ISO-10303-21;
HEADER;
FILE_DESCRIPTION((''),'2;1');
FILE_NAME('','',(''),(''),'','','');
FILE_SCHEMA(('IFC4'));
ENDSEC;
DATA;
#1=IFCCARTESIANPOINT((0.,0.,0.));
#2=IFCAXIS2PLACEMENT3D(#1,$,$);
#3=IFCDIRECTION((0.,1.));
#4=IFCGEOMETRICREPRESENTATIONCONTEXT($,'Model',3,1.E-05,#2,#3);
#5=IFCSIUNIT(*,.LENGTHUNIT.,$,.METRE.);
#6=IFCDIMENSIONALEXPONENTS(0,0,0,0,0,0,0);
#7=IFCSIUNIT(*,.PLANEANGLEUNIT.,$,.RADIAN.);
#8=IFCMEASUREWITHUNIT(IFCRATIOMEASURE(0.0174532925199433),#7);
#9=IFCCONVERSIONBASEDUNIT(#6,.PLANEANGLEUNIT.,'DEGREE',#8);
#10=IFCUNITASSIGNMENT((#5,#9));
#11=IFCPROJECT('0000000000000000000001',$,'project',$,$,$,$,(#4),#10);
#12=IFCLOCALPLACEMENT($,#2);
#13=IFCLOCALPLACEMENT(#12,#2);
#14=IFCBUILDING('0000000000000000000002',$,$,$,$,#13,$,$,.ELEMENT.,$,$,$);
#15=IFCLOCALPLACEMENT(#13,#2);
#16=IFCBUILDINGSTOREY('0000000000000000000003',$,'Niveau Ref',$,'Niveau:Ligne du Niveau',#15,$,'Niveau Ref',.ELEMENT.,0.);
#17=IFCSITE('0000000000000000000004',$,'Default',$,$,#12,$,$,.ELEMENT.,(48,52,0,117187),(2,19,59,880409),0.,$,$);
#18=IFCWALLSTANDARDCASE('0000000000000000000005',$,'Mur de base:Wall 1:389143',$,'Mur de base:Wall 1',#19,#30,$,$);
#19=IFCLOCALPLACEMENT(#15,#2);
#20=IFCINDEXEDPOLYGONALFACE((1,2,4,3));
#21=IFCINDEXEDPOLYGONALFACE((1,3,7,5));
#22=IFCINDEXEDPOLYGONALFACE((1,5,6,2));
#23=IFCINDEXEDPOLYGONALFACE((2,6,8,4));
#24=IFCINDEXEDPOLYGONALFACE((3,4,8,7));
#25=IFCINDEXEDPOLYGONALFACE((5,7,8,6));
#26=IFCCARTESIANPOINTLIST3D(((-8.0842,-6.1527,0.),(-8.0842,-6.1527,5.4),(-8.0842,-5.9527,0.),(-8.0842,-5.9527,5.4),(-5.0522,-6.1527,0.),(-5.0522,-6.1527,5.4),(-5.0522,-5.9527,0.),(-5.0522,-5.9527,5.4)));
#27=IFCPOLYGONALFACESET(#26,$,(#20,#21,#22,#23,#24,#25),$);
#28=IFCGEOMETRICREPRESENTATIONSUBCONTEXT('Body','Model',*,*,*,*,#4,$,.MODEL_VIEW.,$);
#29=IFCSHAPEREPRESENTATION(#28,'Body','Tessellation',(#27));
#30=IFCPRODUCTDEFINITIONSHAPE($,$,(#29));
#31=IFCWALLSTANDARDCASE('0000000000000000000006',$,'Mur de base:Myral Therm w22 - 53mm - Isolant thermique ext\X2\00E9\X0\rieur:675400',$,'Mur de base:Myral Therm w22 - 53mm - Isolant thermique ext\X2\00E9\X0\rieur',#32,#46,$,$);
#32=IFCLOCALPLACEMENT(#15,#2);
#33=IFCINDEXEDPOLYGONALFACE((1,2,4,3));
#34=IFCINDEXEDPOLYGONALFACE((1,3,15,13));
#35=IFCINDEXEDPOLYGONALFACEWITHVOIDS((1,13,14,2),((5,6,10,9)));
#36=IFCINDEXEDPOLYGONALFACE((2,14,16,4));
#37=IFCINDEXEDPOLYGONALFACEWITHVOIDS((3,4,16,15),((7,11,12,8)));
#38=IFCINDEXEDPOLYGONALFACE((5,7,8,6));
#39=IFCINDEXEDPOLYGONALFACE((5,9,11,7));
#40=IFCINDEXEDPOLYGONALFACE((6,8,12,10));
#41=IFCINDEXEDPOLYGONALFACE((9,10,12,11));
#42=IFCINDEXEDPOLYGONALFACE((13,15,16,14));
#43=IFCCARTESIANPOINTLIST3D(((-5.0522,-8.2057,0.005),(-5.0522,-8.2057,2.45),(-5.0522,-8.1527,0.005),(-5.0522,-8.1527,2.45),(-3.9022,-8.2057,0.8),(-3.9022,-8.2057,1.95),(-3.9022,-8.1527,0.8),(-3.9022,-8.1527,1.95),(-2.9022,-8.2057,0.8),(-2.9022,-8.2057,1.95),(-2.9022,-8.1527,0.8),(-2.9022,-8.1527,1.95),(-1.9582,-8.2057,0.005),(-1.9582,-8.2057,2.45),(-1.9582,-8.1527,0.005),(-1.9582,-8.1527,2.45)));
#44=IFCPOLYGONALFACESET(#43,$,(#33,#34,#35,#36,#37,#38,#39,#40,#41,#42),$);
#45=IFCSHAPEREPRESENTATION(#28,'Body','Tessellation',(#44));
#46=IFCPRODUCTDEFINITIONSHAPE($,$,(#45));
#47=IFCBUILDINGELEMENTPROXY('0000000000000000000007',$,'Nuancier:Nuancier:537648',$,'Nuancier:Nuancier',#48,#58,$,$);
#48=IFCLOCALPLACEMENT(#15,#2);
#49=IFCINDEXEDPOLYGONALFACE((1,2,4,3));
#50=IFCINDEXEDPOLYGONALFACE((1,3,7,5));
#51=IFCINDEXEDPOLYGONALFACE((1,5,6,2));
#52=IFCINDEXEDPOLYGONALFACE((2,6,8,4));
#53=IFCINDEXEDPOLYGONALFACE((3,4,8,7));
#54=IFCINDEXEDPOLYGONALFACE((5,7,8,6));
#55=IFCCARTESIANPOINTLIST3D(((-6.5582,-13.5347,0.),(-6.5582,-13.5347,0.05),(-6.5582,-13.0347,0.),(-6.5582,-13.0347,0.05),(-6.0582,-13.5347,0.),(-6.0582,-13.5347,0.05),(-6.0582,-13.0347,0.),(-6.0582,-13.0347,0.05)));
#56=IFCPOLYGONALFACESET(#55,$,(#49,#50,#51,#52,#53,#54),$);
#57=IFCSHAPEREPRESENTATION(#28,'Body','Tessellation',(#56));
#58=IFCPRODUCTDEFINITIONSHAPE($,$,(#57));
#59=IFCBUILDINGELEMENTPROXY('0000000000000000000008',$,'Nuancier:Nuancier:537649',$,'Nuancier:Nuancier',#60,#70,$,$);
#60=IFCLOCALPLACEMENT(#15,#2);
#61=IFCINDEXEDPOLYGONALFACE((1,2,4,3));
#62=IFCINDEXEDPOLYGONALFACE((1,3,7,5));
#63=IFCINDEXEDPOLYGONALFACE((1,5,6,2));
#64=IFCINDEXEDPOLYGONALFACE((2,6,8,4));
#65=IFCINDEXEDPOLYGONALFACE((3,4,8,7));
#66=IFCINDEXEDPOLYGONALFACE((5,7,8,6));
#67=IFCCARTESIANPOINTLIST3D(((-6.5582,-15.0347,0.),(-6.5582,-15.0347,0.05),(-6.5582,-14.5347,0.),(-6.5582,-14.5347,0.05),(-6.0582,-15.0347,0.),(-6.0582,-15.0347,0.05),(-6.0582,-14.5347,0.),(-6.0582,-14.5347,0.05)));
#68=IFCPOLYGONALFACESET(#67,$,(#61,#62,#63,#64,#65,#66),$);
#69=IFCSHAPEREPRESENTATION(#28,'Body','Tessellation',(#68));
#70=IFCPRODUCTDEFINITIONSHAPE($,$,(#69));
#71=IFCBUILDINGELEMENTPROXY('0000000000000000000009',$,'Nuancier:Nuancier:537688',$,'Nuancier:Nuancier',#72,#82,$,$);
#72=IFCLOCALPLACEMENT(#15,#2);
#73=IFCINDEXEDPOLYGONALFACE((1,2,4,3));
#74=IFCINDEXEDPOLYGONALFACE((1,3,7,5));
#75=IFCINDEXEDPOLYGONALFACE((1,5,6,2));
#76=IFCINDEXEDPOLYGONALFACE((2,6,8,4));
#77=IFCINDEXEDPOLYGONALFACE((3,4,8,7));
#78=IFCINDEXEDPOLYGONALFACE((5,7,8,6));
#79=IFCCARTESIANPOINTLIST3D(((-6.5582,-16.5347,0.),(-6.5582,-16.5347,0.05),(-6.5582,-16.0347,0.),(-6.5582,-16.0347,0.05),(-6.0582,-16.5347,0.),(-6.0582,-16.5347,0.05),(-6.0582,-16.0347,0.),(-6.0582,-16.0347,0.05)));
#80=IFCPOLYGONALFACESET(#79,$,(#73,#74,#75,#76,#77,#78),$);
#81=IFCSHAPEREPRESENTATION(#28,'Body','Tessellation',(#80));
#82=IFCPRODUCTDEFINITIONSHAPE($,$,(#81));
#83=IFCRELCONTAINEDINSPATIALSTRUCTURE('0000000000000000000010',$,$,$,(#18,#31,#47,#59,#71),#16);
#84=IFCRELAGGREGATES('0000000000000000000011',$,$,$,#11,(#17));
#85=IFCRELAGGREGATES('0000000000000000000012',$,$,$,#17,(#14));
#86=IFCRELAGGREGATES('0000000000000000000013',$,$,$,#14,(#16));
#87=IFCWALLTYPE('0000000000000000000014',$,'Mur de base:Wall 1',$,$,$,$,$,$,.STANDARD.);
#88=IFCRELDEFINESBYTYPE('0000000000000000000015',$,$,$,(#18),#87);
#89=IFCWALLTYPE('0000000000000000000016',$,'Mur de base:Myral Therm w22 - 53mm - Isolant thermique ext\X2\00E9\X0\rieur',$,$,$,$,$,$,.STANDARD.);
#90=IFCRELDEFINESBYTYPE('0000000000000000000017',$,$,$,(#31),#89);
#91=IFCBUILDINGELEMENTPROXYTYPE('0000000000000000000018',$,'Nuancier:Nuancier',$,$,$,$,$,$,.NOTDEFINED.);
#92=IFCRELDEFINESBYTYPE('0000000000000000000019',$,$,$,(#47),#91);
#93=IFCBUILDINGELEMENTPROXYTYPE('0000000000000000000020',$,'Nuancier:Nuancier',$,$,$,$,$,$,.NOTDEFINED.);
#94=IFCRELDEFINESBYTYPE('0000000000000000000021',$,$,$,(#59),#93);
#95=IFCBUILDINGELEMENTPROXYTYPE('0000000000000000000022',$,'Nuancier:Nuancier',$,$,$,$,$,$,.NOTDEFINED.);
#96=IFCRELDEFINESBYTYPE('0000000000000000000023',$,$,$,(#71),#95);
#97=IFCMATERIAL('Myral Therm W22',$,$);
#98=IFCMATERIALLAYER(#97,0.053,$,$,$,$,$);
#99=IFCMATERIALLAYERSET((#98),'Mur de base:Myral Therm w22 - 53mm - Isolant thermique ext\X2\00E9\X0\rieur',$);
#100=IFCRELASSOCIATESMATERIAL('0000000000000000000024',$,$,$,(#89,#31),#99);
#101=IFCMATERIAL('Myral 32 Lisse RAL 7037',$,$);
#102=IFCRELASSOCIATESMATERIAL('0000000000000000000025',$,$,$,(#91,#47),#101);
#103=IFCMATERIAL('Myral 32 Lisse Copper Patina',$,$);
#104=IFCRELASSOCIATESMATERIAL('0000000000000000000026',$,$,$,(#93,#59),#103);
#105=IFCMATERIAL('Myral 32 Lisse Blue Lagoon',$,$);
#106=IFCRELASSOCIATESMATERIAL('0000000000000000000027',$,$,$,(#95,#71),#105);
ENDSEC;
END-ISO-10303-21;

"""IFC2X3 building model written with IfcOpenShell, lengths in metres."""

from ifc_helpers import new_model, entity, si_unit, converted_unit, direction, frame, frame_2d, origin, origin_2d_with_axis, place, context, subcontext, project, spatial, rectangle, extrude, source, transform, mapped, material, layer, layer_set, layer_usage, type_object, type_shapes, element, save


model = new_model("IFC2X3")

# Units and contexts
model_context = context("Model", 3, precision=1e-05, world=origin(), true_north=direction((0.0, 1.0)))
body_context = subcontext(model_context, "Body", "Model", "MODEL_VIEW")
ifc_project = project(units=[si_unit("LENGTHUNIT", "METRE"), converted_unit("PLANEANGLEUNIT", "DEGREE", entity("IfcRatioMeasure", 0.0174532925199433), si_unit("PLANEANGLEUNIT", "RADIAN"), dimensions=[0, 0, 0, 0, 0, 0, 0])], contexts=[model_context])

# Site, building, storey
site_placement = place(None, origin())
site = spatial("IfcSite", under=ifc_project, at=site_placement, Name="Default", CompositionType="ELEMENT", RefLatitude=(48, 52, 0, 117187), RefLongitude=(2, 19, 59, 880409), RefElevation=0.0)
building_placement = place(site_placement, origin())
building = spatial("IfcBuilding", under=site, at=building_placement, CompositionType="ELEMENT")
storey_placement = place(building_placement, origin())
storey = spatial("IfcBuildingStorey", under=building, at=storey_placement, Name="Niveau Ref", ObjectType="Niveau:Ligne du Niveau", LongName="Niveau Ref", CompositionType="ELEMENT", Elevation=0.0)

# Wall
wall_type_1 = type_object("IfcWallType", Name="Mur de base:Wall 1", PredefinedType="STANDARD")
wall_1_placement = place(storey_placement, frame((-5.0522, -6.0527, 0.0), z_axis=(0.0, 0.0, 1.0), x_axis=(-1.0, 0.0, 0.0)))
element("IfcWallStandardCase", 1, at=wall_1_placement, inside=storey, type_object=wall_type_1, Name="Mur de base:Wall 1:389143", ObjectType="Mur de base:Wall 1", context=body_context, shape_type="SweptSolid", body=[
    extrude(rectangle(XDim=3.032, YDim=0.2, at=frame_2d((1.516, 0.0), x_axis=(-1.0, 0.0))), origin(), (0.0, 0.0, 1.0), 5.4),
])

# Wall, opening
ifc_material_1 = material(Name="Myral Therm W22")
ifc_layer = layer(ifc_material_1, 0.053)
ifc_layer_set = layer_set([ifc_layer], Name="Mur de base:Myral Therm w22 - 53mm - Isolant thermique extérieur")
ifc_layer_usage = layer_usage(ifc_layer_set, "AXIS2", "NEGATIVE", 0.0265)
wall_type_2 = type_object("IfcWallType", Name="Mur de base:Myral Therm w22 - 53mm - Isolant thermique extérieur", PredefinedType="STANDARD", material=ifc_layer_set)
wall_2_placement = place(storey_placement, frame((-5.0522, -8.1792, 0.005)))
wall_2 = element("IfcWallStandardCase", 2, at=wall_2_placement, inside=storey, type_object=wall_type_2, material=ifc_layer_usage, Name="Mur de base:Myral Therm w22 - 53mm - Isolant thermique extérieur:675400", ObjectType="Mur de base:Myral Therm w22 - 53mm - Isolant thermique extérieur", context=body_context, shape_type="SweptSolid", body=[
    extrude(rectangle(XDim=3.094, YDim=0.053, at=frame_2d((1.547, 0.0), x_axis=(-1.0, 0.0))), origin(), (0.0, 0.0, 1.0), 2.445),
])
opening_placement = place(wall_2_placement, origin())
element("IfcOpeningElement", 3, at=opening_placement, cuts=wall_2, ObjectType="Opening", context=body_context, shape_type="SweptSolid", body=[
    extrude(rectangle(XDim=1.15, YDim=1.0, at=frame_2d((0.0, 0.0), x_axis=(0.0, 1.0))), frame((1.65, 0.0265, 1.37), z_axis=(0.0, -1.0, 0.0), x_axis=(-1.0, 0.0, 0.0)), (0.0, 0.0, 1.0), 0.053),
])

# Building element proxies
ifc_material_2 = material(Name="Myral 32 Lisse RAL 7037")
building_element_proxy_type_1 = type_object("IfcBuildingElementProxyType", Name="Nuancier:Nuancier", PredefinedType="NOTDEFINED", material=ifc_material_2)
shared_shape_1 = source(origin(), body_context, "Body", "SweptSolid", [
    extrude(rectangle(XDim=0.5, YDim=0.5, at=origin_2d_with_axis()), frame((0.0, 0.0, 0.0), z_axis=(0.0, 0.0, 1.0), x_axis=(-1.0, 0.0, 0.0)), (0.0, 0.0, 1.0), 0.05),
])
type_shapes(building_element_proxy_type_1, [shared_shape_1])
proxy_1_placement = place(storey_placement, frame((-6.3082, -13.2847, 0.0)))
element("IfcBuildingElementProxy", 4, at=proxy_1_placement, inside=storey, type_object=building_element_proxy_type_1, material=ifc_material_2, Name="Nuancier:Nuancier:537648", ObjectType="Nuancier:Nuancier", context=body_context, shape_type="MappedRepresentation", body=[
    mapped(shared_shape_1, transform((0.0, 0.0, 0.0), scale=1.0)),
])
ifc_material_3 = material(Name="Myral 32 Lisse Copper Patina")
building_element_proxy_type_2 = type_object("IfcBuildingElementProxyType", Name="Nuancier:Nuancier", PredefinedType="NOTDEFINED", material=ifc_material_3)
shared_shape_2 = source(origin(), body_context, "Body", "SweptSolid", [
    extrude(rectangle(XDim=0.5, YDim=0.5, at=origin_2d_with_axis()), frame((0.0, 0.0, 0.0), z_axis=(0.0, 0.0, 1.0), x_axis=(-1.0, 0.0, 0.0)), (0.0, 0.0, 1.0), 0.05),
])
type_shapes(building_element_proxy_type_2, [shared_shape_2])
proxy_2_placement = place(storey_placement, frame((-6.3082, -14.7847, 0.0)))
element("IfcBuildingElementProxy", 5, at=proxy_2_placement, inside=storey, type_object=building_element_proxy_type_2, material=ifc_material_3, Name="Nuancier:Nuancier:537649", ObjectType="Nuancier:Nuancier", context=body_context, shape_type="MappedRepresentation", body=[
    mapped(shared_shape_2, transform((0.0, 0.0, 0.0), scale=1.0)),
])
ifc_material_4 = material(Name="Myral 32 Lisse Blue Lagoon")
building_element_proxy_type_3 = type_object("IfcBuildingElementProxyType", Name="Nuancier:Nuancier", PredefinedType="NOTDEFINED", material=ifc_material_4)
shared_shape_3 = source(origin(), body_context, "Body", "SweptSolid", [
    extrude(rectangle(XDim=0.5, YDim=0.5, at=origin_2d_with_axis()), frame((0.0, 0.0, 0.0), z_axis=(0.0, 0.0, 1.0), x_axis=(-1.0, 0.0, 0.0)), (0.0, 0.0, 1.0), 0.05),
])
type_shapes(building_element_proxy_type_3, [shared_shape_3])
proxy_3_placement = place(storey_placement, frame((-6.3082, -16.2847, 0.0)))
element("IfcBuildingElementProxy", 6, at=proxy_3_placement, inside=storey, type_object=building_element_proxy_type_3, material=ifc_material_4, Name="Nuancier:Nuancier:537688", ObjectType="Nuancier:Nuancier", context=body_context, shape_type="MappedRepresentation", body=[
    mapped(shared_shape_3, transform((0.0, 0.0, 0.0), scale=1.0)),
])

save(model, "model.ifc")
